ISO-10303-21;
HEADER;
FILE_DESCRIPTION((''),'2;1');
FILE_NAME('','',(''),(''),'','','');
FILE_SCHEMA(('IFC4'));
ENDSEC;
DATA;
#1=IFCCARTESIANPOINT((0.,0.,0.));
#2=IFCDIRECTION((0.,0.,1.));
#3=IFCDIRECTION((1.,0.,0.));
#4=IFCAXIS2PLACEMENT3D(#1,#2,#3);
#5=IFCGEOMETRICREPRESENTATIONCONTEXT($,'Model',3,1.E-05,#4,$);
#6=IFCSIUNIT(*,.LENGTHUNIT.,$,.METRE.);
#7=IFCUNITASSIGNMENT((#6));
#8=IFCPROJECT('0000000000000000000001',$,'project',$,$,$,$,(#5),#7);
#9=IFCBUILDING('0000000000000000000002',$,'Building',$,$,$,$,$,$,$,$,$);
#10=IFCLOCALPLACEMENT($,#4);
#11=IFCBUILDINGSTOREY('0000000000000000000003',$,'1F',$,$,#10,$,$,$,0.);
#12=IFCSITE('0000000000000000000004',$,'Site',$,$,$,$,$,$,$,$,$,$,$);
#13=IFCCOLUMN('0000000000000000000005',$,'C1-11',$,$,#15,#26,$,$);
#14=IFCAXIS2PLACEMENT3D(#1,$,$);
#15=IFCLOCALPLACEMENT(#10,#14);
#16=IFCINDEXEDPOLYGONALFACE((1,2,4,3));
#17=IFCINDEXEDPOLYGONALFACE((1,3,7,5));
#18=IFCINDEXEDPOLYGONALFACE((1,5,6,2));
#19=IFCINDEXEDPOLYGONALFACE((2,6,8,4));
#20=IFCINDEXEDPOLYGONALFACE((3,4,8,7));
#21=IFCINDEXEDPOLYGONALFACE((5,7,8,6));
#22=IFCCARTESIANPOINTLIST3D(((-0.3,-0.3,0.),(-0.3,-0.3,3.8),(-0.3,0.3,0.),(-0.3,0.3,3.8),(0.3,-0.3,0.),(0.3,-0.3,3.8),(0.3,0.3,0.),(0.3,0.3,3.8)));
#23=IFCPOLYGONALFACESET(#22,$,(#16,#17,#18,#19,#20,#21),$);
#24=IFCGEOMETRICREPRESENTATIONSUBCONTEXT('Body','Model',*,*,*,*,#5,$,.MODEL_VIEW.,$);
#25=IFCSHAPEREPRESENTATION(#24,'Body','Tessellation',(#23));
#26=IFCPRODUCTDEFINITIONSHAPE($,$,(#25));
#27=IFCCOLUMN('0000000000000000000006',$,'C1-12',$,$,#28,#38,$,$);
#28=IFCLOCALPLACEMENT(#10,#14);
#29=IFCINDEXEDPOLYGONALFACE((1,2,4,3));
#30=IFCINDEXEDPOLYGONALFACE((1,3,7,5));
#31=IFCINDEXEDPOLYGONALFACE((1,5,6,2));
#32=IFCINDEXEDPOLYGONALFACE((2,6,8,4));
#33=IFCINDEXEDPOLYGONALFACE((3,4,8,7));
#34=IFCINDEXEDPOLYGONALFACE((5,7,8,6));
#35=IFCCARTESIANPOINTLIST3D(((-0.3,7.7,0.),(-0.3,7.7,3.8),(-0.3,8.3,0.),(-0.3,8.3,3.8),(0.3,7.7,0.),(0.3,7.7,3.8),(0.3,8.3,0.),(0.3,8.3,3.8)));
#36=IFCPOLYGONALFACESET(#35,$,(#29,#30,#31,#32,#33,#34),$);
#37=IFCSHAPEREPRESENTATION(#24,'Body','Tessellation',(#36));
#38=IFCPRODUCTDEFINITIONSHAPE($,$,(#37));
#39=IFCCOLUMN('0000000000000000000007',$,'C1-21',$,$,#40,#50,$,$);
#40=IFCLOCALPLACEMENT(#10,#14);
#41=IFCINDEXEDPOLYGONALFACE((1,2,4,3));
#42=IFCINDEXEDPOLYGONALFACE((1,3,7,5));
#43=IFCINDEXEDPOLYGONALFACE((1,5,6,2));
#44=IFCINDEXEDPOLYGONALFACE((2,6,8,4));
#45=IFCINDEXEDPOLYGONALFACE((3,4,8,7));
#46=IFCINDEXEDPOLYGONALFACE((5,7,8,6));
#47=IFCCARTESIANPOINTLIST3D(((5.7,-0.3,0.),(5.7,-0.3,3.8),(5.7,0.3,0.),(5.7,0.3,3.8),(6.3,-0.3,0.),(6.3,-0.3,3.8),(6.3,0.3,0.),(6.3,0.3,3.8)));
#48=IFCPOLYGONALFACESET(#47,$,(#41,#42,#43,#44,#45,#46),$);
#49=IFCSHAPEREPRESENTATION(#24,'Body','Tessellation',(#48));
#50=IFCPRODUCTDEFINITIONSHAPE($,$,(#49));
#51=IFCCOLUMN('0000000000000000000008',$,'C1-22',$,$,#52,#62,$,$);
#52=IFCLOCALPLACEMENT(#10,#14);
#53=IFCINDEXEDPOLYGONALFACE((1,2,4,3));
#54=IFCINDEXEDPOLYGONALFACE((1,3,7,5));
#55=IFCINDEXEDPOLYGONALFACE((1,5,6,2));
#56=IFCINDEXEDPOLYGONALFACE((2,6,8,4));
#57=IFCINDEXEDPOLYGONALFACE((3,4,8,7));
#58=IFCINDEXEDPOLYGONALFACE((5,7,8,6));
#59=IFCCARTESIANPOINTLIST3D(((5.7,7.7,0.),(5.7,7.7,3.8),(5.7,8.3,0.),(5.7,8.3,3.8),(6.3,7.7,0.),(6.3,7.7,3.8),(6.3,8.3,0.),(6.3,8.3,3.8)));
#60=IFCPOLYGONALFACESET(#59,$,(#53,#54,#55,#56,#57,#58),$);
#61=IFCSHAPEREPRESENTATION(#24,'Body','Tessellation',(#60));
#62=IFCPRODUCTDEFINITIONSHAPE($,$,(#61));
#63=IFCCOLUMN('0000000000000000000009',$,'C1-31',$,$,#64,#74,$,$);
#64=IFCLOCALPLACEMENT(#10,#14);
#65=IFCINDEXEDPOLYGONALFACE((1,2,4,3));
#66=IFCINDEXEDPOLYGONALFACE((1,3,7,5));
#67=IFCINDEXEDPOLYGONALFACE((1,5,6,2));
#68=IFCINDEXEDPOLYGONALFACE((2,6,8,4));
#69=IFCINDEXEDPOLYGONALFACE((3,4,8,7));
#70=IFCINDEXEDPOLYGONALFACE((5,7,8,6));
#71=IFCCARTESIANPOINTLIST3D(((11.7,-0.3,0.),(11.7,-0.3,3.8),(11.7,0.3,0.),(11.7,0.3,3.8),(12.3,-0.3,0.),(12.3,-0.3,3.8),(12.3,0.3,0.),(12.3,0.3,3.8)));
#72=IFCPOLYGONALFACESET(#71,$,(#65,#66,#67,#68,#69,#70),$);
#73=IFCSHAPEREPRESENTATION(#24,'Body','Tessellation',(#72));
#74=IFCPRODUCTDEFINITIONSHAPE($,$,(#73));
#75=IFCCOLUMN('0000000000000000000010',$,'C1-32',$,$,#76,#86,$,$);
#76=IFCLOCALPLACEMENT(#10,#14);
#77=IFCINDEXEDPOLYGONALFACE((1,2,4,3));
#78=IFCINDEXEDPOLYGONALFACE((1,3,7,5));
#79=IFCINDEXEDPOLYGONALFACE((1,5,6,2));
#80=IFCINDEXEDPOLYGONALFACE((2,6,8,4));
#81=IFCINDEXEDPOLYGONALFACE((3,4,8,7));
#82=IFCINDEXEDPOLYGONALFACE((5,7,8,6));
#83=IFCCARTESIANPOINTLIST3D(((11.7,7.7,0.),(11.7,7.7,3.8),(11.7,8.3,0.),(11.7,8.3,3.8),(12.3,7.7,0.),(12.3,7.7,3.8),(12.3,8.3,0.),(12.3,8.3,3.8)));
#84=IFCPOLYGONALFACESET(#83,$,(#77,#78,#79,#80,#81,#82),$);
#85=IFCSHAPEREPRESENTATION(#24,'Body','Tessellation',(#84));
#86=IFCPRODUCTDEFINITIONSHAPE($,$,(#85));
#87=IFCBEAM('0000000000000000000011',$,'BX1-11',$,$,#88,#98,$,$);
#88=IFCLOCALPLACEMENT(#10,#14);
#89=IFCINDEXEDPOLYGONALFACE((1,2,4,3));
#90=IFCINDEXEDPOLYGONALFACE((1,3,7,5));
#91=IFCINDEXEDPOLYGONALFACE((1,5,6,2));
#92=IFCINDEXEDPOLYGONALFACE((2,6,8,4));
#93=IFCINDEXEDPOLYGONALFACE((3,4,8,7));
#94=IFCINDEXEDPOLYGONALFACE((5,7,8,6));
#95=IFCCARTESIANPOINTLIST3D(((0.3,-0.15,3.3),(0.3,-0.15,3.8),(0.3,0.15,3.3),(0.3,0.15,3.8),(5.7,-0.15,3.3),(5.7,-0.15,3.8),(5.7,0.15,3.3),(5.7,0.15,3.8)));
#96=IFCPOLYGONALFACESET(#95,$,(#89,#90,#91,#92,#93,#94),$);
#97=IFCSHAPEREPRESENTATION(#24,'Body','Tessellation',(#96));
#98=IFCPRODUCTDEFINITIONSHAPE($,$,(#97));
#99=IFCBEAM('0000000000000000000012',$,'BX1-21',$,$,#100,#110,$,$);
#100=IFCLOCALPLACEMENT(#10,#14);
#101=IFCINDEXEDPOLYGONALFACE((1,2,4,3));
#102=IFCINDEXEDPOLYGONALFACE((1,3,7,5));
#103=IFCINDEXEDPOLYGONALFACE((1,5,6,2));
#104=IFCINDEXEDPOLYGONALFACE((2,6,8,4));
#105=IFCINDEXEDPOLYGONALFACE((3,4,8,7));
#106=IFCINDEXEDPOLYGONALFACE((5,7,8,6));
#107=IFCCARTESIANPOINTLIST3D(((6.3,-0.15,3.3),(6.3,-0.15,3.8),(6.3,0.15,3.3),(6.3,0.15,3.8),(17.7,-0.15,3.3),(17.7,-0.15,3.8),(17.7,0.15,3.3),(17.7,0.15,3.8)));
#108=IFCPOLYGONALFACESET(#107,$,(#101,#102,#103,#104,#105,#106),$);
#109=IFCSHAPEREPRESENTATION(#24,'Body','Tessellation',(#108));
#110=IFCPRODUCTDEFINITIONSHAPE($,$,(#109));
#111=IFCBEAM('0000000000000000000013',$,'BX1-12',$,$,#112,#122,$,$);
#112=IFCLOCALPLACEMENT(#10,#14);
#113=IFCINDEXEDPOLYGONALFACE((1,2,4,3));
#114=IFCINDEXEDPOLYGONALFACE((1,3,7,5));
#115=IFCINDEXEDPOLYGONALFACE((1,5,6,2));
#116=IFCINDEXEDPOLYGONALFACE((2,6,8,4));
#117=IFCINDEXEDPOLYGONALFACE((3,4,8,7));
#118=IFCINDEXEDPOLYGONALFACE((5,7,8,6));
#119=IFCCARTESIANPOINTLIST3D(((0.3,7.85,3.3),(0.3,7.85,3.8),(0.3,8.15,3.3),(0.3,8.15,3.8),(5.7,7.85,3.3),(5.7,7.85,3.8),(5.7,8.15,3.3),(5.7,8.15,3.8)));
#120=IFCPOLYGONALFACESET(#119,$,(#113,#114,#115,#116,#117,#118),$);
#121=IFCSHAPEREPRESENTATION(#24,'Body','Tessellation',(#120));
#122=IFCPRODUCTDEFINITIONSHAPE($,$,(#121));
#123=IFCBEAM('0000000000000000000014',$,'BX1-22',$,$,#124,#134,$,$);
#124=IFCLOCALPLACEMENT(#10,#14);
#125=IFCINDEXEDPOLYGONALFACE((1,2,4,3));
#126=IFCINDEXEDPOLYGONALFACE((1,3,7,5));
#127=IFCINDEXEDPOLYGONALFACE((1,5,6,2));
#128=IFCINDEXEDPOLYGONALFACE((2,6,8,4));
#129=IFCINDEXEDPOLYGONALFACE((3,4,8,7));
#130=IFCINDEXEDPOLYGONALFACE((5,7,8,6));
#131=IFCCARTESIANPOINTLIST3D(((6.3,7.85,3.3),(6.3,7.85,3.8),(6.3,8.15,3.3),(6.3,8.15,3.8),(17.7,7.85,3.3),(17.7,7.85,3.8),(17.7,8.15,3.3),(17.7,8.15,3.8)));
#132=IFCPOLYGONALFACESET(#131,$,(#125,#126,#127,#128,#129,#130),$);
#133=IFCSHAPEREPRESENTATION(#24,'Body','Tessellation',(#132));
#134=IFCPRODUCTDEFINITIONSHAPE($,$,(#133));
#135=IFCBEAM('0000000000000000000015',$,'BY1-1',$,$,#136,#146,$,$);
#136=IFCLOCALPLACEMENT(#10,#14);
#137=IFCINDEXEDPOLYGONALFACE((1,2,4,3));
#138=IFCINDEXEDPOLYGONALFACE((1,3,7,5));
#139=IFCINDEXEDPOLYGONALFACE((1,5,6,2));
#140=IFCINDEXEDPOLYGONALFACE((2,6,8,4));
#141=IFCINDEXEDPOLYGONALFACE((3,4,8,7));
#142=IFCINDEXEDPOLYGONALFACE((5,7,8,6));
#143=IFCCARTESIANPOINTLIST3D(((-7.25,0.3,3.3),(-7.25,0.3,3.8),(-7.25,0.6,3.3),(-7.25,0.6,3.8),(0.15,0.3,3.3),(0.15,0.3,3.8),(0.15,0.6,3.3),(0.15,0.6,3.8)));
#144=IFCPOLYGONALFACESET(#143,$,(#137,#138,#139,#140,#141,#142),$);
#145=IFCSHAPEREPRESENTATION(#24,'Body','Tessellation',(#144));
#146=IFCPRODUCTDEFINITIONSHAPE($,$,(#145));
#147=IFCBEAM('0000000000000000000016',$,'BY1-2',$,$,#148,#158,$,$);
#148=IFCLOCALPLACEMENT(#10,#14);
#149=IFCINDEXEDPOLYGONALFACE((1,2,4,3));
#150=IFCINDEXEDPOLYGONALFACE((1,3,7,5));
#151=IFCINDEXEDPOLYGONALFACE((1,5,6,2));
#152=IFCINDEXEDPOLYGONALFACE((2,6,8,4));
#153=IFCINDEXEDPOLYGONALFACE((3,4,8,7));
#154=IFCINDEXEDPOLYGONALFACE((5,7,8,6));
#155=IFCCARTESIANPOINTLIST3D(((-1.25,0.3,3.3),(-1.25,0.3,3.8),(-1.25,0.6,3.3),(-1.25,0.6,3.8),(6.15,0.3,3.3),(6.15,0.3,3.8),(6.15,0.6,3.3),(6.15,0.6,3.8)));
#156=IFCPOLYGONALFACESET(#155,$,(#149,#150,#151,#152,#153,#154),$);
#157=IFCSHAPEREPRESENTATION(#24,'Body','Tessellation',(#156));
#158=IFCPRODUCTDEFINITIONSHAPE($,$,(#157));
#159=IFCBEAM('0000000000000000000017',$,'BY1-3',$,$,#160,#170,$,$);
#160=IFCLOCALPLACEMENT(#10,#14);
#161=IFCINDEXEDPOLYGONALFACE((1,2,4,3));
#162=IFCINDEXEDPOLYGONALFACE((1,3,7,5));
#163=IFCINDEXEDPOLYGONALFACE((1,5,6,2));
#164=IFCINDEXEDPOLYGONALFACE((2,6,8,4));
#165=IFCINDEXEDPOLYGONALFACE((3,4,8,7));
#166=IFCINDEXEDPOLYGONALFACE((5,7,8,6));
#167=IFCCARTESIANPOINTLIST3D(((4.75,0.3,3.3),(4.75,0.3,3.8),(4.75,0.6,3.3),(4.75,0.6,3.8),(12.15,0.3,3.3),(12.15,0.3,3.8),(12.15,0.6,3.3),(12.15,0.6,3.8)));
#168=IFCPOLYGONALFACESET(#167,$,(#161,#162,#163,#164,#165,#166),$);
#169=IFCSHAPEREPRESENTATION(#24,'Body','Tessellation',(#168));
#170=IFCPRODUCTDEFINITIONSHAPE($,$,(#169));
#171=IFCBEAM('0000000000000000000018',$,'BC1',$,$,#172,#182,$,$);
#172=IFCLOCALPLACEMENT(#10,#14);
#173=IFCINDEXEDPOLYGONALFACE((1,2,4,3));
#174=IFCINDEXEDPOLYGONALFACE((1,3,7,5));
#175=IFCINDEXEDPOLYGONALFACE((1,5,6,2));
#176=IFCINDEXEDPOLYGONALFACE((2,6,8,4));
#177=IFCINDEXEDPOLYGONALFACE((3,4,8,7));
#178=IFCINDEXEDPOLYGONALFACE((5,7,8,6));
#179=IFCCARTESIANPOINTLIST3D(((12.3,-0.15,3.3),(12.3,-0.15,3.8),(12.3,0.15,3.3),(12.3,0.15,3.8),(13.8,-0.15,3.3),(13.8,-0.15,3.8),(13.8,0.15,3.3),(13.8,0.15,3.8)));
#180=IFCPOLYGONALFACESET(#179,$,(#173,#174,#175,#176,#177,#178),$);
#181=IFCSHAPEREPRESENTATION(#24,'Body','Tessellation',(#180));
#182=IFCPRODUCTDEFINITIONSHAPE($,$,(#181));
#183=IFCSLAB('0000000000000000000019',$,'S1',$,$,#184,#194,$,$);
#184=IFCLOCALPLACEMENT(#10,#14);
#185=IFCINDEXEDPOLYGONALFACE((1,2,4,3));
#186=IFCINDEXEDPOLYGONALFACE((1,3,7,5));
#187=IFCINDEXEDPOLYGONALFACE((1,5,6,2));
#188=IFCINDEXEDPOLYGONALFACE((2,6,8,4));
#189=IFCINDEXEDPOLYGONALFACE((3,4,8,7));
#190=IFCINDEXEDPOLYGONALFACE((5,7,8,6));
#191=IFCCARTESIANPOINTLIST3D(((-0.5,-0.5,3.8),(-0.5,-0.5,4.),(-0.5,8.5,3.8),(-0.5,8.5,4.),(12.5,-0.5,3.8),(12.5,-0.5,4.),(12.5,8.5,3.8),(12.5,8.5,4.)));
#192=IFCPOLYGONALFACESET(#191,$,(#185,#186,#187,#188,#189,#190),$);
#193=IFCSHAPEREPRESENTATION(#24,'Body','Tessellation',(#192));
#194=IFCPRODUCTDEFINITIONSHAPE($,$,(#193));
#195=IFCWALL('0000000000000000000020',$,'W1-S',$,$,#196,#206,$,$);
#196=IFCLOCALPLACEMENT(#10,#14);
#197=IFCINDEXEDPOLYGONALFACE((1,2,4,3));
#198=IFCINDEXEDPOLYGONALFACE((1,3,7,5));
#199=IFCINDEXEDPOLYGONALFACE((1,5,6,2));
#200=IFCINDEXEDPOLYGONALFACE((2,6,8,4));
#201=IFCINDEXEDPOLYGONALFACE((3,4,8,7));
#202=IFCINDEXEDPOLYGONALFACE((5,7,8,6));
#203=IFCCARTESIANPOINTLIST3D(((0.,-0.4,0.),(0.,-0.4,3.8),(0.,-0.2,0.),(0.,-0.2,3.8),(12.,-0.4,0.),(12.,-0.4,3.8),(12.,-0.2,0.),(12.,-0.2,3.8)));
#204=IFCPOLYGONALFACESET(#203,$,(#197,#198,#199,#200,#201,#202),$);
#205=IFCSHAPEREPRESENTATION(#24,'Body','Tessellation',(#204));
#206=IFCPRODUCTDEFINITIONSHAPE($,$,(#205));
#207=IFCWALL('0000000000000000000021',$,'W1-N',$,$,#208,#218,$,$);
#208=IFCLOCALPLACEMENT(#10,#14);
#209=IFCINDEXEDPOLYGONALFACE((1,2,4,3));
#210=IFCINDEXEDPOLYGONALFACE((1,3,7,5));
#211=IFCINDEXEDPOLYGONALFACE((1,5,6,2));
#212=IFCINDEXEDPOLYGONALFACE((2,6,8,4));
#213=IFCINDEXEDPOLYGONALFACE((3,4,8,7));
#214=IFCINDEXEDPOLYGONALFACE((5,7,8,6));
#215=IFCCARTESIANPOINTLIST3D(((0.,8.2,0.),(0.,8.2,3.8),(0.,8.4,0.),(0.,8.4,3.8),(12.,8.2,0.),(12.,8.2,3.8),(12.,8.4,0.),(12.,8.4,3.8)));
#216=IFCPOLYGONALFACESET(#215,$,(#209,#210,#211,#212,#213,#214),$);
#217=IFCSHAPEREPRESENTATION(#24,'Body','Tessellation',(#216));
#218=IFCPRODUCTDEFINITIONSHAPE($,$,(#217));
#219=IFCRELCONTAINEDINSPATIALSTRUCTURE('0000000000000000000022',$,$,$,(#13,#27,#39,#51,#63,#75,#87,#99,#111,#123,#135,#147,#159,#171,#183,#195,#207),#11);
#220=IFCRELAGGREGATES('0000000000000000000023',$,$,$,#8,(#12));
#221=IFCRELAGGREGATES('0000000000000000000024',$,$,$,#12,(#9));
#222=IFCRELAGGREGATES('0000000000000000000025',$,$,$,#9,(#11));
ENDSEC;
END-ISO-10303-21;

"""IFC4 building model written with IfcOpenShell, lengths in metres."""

from ifc_helpers import new_model, si_unit, frame, origin_with_axes, place, context, subcontext, project, spatial, indexed_curve, outline, extrude, shape, element, save


model = new_model("IFC4")

# Units and contexts
model_context = context("Model", 3, precision=1e-05, world=origin_with_axes())
body_context = subcontext(model_context, "Body", "Model", "MODEL_VIEW")
ifc_project = project(units=[si_unit("LENGTHUNIT", "METRE")], contexts=[model_context])

# Site, building, storey
site = spatial("IfcSite", under=ifc_project, Name="Site")
building = spatial("IfcBuilding", under=site, Name="Building")
storey_placement = place(None, origin_with_axes())
storey = spatial("IfcBuildingStorey", under=building, at=storey_placement, Name="1F", Elevation=0.0)

# Columns
for number, where, z_axis, x_axis, name in (
    (1, (-0.3, -0.3, 0.0), (0.0, 0.0, 1.0), (1.0, 0.0, 0.0), "C1-11"),
    (2, (-0.3, 7.7, 0.0), (0.0, 0.0, 1.0), (1.0, 0.0, 0.0), "C1-12"),
    (3, (5.7, -0.3, 0.0), (0.0, 0.0, 1.0), (1.0, 0.0, 0.0), "C1-21"),
    (4, (5.7, 7.7, 0.0), (0.0, 0.0, 1.0), (1.0, 0.0, 0.0), "C1-22"),
    (5, (11.7, -0.3, 0.0), (0.0, 0.0, 1.0), (1.0, 0.0, 0.0), "C1-31"),
    (6, (11.7, 7.7, 0.0), (0.0, 0.0, 1.0), (1.0, 0.0, 0.0), "C1-32"),
):
    element("IfcColumn", number, at=place(storey_placement, frame(where, z_axis=z_axis, x_axis=x_axis)), inside=storey, Name=name, context=body_context, shape_type="SweptSolid", body=[
        extrude(outline(indexed_curve([(0.0, 0.0), (0.0, 0.6), (0.6, 0.6), (0.6, 0.0), (0.0, 0.0)], self_intersect=False)), origin_with_axes(), (0.0, 0.0, 1.0), 3.8),
    ])

# Beams
beam_1_placement = place(storey_placement, frame((0.3, -0.15, 3.3), z_axis=(0.0, 0.0, 1.0), x_axis=(1.0, 0.0, 0.0)))
element("IfcBeam", 7, at=beam_1_placement, inside=storey, Name="BX1-11", context=body_context, shape_type="SweptSolid", body=[
    extrude(outline(indexed_curve([(0.0, 0.0), (0.0, 0.3), (5.4, 0.3), (5.4, 0.0), (0.0, 0.0)], self_intersect=False)), origin_with_axes(), (0.0, 0.0, 1.0), 0.5),
])
beam_2_placement = place(storey_placement, frame((6.3, -0.15, 3.3), z_axis=(0.0, 0.0, 1.0), x_axis=(1.0, 0.0, 0.0)))
element("IfcBeam", 8, at=beam_2_placement, inside=storey, Name="BX1-21", context=body_context, shape_type="SweptSolid", body=[
    extrude(outline(indexed_curve([(0.0, 0.0), (0.0, 0.3), (11.4, 0.3), (11.4, 0.0), (0.0, 0.0)], self_intersect=False)), origin_with_axes(), (0.0, 0.0, 1.0), 0.5),
])
beam_3_placement = place(storey_placement, frame((0.3, 7.85, 3.3), z_axis=(0.0, 0.0, 1.0), x_axis=(1.0, 0.0, 0.0)))
element("IfcBeam", 9, at=beam_3_placement, inside=storey, Name="BX1-12", context=body_context, shape_type="SweptSolid", body=[
    extrude(outline(indexed_curve([(0.0, 0.0), (0.0, 0.3), (5.4, 0.3), (5.4, 0.0), (0.0, 0.0)], self_intersect=False)), origin_with_axes(), (0.0, 0.0, 1.0), 0.5),
])
beam_4_placement = place(storey_placement, frame((6.3, 7.85, 3.3), z_axis=(0.0, 0.0, 1.0), x_axis=(1.0, 0.0, 0.0)))
element("IfcBeam", 10, at=beam_4_placement, inside=storey, Name="BX1-22", context=body_context, shape_type="SweptSolid", body=[
    extrude(outline(indexed_curve([(0.0, 0.0), (0.0, 0.3), (11.4, 0.3), (11.4, 0.0), (0.0, 0.0)], self_intersect=False)), origin_with_axes(), (0.0, 0.0, 1.0), 0.5),
])
for number, where, z_axis, x_axis, name in (
    (11, (0.15, 0.3, 3.3), (0.0, 0.0, 1.0), (0.0, 1.0, 0.0), "BY1-1"),
    (12, (6.15, 0.3, 3.3), (0.0, 0.0, 1.0), (0.0, 1.0, 0.0), "BY1-2"),
    (13, (12.15, 0.3, 3.3), (0.0, 0.0, 1.0), (0.0, 1.0, 0.0), "BY1-3"),
):
    element("IfcBeam", number, at=place(storey_placement, frame(where, z_axis=z_axis, x_axis=x_axis)), inside=storey, Name=name, shapes=[
        shape(body_context, "Body", "SweptSolid", [extrude(outline(indexed_curve([(0.0, 0.0), (0.0, 7.4), (0.3, 7.4), (0.3, 0.0), (0.0, 0.0)], self_intersect=False)), origin_with_axes(), (0.0, 0.0, 1.0), 0.5)]),
        shape(body_context, "Body", "SweptSolid", [extrude(outline(indexed_curve([(0.0, 0.0), (0.0, 0.3), (7.4, 0.3), (7.4, 0.0), (0.0, 0.0)], self_intersect=False)), origin_with_axes(), (0.0, 0.0, 1.0), 0.5)]),
    ])
beam_5_placement = place(storey_placement, frame((12.3, -0.15, 3.3), z_axis=(0.0, 0.0, 1.0), x_axis=(1.0, 0.0, 0.0)))
element("IfcBeam", 14, at=beam_5_placement, inside=storey, Name="BC1", context=body_context, shape_type="SweptSolid", body=[
    extrude(outline(indexed_curve([(0.0, 0.0), (0.0, 0.3), (1.5, 0.3), (1.5, 0.0), (0.0, 0.0)], self_intersect=False)), origin_with_axes(), (0.0, 0.0, 1.0), 0.5),
])

# Slab
slab_placement = place(storey_placement, frame((-0.5, -0.5, 3.8), z_axis=(0.0, 0.0, 1.0), x_axis=(1.0, 0.0, 0.0)))
element("IfcSlab", 15, at=slab_placement, inside=storey, Name="S1", context=body_context, shape_type="SweptSolid", body=[
    extrude(outline(indexed_curve([(0.0, 0.0), (0.0, 9.0), (13.0, 9.0), (13.0, 0.0), (0.0, 0.0)], self_intersect=False)), origin_with_axes(), (0.0, 0.0, 1.0), 0.2),
])

# Walls
for number, where, z_axis, x_axis, name in (
    (16, (0.0, -0.4, 0.0), (0.0, 0.0, 1.0), (1.0, 0.0, 0.0), "W1-S"),
    (17, (0.0, 8.2, 0.0), (0.0, 0.0, 1.0), (1.0, 0.0, 0.0), "W1-N"),
):
    element("IfcWall", number, at=place(storey_placement, frame(where, z_axis=z_axis, x_axis=x_axis)), inside=storey, Name=name, context=body_context, shape_type="SweptSolid", body=[
        extrude(outline(indexed_curve([(0.0, 0.0), (0.0, 0.2), (12.0, 0.2), (12.0, 0.0), (0.0, 0.0)], self_intersect=False)), origin_with_axes(), (0.0, 0.0, 1.0), 3.8),
    ])

save(model, "model.ifc")
